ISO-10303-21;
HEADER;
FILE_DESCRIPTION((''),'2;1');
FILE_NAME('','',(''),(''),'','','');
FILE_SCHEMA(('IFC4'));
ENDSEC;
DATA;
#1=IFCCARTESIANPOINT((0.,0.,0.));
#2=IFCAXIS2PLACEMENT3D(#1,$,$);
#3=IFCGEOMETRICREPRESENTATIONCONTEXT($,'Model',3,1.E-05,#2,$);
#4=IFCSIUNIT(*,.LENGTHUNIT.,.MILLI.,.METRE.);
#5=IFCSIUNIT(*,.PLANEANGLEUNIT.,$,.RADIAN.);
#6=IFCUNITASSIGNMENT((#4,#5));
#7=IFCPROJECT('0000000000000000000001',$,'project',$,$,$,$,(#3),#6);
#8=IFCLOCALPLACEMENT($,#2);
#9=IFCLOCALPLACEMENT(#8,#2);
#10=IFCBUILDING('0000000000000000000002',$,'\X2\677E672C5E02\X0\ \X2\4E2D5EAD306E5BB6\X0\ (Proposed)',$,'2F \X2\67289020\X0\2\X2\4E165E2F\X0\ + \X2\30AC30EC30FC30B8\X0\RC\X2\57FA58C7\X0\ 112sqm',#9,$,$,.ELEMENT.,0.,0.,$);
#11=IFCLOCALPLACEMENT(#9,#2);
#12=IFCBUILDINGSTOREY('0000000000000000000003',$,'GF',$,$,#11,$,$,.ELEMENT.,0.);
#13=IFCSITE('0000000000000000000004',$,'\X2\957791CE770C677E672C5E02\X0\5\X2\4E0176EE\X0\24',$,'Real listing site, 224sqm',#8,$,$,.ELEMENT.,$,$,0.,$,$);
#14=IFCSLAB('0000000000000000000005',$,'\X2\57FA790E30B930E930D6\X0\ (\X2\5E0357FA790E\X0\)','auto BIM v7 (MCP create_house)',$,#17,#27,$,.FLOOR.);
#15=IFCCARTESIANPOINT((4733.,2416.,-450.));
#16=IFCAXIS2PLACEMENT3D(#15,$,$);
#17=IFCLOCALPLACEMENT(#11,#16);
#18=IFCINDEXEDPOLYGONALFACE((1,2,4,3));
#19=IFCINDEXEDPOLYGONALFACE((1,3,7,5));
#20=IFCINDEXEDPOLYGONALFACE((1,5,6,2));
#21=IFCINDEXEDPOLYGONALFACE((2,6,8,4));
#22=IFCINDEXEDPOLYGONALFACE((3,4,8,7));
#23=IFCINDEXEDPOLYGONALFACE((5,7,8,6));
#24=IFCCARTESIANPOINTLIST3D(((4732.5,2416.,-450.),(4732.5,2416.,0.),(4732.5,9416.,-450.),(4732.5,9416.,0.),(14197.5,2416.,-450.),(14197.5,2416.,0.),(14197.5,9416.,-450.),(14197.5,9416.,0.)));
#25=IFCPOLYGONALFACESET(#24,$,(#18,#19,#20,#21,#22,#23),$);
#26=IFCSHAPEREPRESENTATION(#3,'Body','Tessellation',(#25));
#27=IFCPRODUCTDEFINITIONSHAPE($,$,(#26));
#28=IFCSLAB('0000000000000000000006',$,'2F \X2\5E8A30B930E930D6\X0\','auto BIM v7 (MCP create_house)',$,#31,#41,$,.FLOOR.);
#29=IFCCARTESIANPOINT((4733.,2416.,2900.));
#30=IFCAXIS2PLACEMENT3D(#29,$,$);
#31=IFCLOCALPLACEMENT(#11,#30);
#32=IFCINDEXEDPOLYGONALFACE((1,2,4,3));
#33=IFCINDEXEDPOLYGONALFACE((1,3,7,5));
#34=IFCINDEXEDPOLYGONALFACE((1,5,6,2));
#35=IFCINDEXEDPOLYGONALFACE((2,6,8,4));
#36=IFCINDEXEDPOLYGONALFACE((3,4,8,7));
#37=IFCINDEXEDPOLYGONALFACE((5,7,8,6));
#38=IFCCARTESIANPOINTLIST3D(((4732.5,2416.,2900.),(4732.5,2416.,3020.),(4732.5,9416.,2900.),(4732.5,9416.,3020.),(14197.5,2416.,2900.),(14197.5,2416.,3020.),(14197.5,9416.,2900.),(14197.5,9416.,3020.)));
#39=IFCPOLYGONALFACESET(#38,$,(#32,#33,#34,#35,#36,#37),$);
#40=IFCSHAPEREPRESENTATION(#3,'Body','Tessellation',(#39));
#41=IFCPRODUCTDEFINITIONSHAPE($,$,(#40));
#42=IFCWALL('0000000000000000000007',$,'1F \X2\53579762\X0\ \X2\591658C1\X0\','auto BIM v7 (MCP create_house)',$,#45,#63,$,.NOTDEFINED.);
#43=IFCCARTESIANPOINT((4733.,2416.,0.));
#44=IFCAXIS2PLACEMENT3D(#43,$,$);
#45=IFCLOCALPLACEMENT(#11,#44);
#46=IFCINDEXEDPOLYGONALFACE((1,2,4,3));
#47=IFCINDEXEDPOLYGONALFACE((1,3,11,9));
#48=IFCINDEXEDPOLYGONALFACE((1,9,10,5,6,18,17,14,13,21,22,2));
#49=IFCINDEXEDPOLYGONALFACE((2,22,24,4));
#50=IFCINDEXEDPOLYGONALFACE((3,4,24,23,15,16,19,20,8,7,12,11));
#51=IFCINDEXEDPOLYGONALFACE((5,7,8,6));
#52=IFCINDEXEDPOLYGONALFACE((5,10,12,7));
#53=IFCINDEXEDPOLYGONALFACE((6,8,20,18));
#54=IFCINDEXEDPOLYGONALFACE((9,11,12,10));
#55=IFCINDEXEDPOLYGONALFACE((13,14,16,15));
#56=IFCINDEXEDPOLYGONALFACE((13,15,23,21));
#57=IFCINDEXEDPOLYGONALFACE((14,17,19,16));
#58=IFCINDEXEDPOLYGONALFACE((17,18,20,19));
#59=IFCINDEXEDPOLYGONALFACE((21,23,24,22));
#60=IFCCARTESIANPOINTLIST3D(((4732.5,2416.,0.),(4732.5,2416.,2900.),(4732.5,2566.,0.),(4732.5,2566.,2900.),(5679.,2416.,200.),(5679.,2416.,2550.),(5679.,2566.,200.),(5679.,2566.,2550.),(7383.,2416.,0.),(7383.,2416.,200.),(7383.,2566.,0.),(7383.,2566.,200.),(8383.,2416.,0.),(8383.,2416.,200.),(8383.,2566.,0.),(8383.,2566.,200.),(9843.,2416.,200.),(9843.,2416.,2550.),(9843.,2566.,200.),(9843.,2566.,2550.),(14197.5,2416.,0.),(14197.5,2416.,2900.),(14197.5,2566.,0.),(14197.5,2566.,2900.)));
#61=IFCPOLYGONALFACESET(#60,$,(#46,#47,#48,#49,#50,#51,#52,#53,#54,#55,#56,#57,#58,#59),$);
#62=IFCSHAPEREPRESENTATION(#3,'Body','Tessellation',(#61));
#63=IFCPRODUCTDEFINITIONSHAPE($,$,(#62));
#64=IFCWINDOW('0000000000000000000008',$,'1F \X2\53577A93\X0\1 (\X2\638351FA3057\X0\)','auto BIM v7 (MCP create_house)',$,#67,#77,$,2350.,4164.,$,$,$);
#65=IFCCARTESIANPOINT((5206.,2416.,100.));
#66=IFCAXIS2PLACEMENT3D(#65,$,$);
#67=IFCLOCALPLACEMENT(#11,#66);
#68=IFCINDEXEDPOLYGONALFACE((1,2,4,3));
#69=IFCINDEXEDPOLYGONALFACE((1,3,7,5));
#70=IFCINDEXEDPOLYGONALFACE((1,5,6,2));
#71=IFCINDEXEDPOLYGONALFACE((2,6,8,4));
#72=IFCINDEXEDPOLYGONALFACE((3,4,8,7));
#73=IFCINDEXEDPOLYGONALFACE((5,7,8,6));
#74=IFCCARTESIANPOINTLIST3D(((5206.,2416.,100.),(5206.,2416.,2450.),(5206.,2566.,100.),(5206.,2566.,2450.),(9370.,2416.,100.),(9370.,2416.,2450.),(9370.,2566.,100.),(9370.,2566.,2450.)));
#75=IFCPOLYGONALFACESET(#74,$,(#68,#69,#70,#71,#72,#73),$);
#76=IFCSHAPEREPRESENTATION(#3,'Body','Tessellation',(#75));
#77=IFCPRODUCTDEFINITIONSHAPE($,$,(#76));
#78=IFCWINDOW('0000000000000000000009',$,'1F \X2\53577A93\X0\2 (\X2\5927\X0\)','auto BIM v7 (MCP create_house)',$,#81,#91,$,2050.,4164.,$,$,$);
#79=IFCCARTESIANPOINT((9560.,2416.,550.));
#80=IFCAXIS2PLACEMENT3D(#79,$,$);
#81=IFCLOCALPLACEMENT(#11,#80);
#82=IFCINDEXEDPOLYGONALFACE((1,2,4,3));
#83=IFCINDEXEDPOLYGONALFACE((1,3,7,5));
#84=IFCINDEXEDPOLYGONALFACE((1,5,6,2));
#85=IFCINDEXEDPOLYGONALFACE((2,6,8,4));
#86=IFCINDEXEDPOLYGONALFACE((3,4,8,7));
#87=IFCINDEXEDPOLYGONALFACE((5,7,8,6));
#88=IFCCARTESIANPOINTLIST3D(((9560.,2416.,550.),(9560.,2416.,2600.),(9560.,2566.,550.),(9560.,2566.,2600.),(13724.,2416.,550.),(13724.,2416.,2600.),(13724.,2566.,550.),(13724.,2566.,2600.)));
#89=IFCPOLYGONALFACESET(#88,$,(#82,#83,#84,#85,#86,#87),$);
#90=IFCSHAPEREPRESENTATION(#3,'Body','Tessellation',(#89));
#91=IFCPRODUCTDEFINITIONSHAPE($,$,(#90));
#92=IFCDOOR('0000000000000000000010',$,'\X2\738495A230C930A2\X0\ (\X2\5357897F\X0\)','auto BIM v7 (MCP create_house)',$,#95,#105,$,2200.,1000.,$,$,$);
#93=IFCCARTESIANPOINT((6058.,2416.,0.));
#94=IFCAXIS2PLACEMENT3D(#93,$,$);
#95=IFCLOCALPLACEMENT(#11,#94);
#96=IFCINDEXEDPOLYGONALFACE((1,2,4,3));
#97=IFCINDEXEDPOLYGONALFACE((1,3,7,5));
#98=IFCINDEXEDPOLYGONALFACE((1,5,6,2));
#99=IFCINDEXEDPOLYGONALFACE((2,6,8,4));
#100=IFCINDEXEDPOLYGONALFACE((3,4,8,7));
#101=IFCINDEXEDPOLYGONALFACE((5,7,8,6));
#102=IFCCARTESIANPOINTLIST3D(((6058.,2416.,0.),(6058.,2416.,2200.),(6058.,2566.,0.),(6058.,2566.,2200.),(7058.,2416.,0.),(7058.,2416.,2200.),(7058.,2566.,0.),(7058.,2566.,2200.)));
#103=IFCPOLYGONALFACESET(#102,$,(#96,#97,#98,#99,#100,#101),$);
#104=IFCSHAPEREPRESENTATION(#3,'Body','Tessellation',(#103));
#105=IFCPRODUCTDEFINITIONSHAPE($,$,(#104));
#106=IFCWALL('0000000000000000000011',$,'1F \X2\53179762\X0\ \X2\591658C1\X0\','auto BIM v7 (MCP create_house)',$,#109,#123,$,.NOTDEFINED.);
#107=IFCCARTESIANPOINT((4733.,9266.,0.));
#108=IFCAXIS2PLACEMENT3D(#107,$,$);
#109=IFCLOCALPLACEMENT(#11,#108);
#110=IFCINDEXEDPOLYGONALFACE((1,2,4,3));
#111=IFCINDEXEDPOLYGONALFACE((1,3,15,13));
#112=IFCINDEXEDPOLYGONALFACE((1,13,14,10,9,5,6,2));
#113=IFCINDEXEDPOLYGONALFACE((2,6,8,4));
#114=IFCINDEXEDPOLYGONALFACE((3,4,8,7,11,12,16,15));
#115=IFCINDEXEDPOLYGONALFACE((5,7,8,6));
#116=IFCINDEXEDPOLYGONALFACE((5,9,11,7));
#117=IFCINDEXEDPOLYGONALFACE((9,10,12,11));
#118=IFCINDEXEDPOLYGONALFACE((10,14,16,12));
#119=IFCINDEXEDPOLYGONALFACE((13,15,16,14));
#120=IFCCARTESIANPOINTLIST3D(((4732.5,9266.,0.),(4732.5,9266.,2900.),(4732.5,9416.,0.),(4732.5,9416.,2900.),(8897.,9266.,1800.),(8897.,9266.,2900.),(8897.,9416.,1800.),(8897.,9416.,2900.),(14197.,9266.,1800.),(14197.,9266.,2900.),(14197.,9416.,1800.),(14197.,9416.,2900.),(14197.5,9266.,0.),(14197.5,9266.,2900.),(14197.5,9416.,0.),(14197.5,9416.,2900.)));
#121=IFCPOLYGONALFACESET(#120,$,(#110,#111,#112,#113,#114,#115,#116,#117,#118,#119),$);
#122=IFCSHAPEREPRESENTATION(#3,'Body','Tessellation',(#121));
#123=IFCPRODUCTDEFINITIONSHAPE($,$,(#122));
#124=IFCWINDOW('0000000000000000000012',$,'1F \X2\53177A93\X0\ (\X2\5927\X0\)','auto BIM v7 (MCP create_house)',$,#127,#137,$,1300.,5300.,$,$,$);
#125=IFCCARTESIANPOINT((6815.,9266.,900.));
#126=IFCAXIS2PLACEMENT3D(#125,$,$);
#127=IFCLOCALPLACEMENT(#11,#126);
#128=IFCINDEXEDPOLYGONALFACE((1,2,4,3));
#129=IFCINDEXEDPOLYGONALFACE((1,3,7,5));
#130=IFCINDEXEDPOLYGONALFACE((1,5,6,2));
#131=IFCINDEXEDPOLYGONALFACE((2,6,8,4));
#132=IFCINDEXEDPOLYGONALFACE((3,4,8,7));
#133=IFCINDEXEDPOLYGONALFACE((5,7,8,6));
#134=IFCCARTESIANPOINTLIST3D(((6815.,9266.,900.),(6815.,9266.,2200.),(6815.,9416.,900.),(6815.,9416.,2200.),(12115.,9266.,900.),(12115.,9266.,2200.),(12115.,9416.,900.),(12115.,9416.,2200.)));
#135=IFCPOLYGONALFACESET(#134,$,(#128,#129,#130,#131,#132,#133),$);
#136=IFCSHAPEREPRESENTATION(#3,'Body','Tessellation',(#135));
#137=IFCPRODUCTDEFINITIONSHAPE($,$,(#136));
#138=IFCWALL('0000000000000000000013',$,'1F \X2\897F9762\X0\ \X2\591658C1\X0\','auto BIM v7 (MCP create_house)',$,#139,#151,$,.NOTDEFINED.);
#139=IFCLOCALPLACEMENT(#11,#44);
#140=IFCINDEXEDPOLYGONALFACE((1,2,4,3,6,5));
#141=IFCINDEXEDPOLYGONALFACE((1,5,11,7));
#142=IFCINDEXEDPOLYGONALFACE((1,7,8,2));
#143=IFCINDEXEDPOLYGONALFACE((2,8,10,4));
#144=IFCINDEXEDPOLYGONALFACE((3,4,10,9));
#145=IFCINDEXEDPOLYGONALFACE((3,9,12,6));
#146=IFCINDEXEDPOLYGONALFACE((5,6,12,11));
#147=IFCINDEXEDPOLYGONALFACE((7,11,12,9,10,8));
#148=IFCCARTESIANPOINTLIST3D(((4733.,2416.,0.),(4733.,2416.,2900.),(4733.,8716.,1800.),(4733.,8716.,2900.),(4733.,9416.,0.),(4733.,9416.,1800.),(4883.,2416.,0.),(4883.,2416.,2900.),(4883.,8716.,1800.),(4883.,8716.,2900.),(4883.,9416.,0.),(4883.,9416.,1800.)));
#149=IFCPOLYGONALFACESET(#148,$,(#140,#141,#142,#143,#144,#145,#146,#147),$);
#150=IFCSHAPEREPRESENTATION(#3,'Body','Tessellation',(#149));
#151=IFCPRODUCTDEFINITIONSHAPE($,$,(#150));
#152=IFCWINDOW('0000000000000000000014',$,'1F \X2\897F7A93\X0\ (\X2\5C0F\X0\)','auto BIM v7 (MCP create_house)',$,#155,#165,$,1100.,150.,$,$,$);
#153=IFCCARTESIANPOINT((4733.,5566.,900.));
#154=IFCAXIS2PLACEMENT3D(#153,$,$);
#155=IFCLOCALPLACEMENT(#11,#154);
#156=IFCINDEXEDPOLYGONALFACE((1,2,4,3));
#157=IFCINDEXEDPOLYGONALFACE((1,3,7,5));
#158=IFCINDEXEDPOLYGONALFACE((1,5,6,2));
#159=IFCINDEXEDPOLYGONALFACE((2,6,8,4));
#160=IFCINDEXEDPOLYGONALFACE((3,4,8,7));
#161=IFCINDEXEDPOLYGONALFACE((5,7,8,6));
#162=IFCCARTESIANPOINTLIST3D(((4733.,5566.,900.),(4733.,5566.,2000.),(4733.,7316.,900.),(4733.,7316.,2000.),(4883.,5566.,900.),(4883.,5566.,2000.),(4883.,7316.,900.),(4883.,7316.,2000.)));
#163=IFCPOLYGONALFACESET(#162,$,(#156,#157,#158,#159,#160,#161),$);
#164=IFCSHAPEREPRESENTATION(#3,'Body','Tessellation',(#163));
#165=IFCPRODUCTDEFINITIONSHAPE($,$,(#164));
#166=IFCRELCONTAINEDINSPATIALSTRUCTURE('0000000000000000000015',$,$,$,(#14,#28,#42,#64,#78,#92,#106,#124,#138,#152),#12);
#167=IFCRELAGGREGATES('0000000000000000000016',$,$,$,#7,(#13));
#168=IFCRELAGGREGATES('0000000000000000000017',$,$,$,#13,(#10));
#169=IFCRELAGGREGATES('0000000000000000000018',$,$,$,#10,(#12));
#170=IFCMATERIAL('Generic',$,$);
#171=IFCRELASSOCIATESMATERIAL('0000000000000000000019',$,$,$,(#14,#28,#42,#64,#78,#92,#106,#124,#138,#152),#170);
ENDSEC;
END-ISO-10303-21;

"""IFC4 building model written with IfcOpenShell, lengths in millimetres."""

from ifc_helpers import new_model, si_unit, frame, frame_2d, origin, place, context, project, spatial, rectangle, extrude, material, element, fill, save


model = new_model("IFC4")

# Units and contexts
model_context = context("Model", 3, precision=1e-05, world=origin())
ifc_project = project(units=[si_unit("LENGTHUNIT", "METRE", prefix="MILLI"), si_unit("PLANEANGLEUNIT", "RADIAN")], contexts=[model_context])

# Site, building, storey
site_placement = place(None, origin())
site = spatial("IfcSite", under=ifc_project, at=site_placement, Name="長野県松本市5丁目24", ObjectType="Real listing site, 224sqm", CompositionType="ELEMENT", RefElevation=0.0)
building_placement = place(site_placement, origin())
building = spatial("IfcBuilding", under=site, at=building_placement, Name="松本市 中庭の家 (Proposed)", ObjectType="2F 木造2世帯 + ガレージRC基壇 112sqm", CompositionType="ELEMENT", ElevationOfRefHeight=0.0, ElevationOfTerrain=0.0)
storey_placement = place(building_placement, origin())
storey = spatial("IfcBuildingStorey", under=building, at=storey_placement, Name="GF", CompositionType="ELEMENT", Elevation=0.0)

# Slabs
ifc_material = material(Name="Generic")
slab_1_placement = place(storey_placement, frame((4733.0, 2416.0, -450.0)))
element("IfcSlab", 1, at=slab_1_placement, inside=storey, material=ifc_material, Name="基礎スラブ (布基礎)", Description="auto BIM v7 (MCP create_house)", PredefinedType="FLOOR", context=model_context, shape_type="SweptSolid", body=[
    extrude(rectangle(XDim=9465.0, YDim=7000.0, at=frame_2d((4732.0, 3500.0))), frame((4733.0, 2416.0, -450.0)), (0.0, 0.0, 1.0), 450.0),
])
slab_2_placement = place(storey_placement, frame((4733.0, 2416.0, 2900.0)))
element("IfcSlab", 2, at=slab_2_placement, inside=storey, material=ifc_material, Name="2F 床スラブ", Description="auto BIM v7 (MCP create_house)", PredefinedType="FLOOR", context=model_context, shape_type="SweptSolid", body=[
    extrude(rectangle(XDim=9465.0, YDim=7000.0, at=frame_2d((4732.0, 3500.0))), frame((4733.0, 2416.0, 2900.0)), (0.0, 0.0, 1.0), 120.0),
])

# Wall, openings, windows, door
wall_1_placement = place(storey_placement, frame((4733.0, 2416.0, 0.0)))
wall_1 = element("IfcWall", 3, at=wall_1_placement, inside=storey, material=ifc_material, Name="1F 南面 外壁", Description="auto BIM v7 (MCP create_house)", PredefinedType="NOTDEFINED", context=model_context, shape_type="SweptSolid", body=[
    extrude(rectangle(XDim=9465.0, YDim=150.0, at=frame_2d((4732.0, 75.0))), frame((4733.0, 2416.0, 0.0)), (0.0, 0.0, 1.0), 2900.0),
])
opening_1_placement = place(storey_placement, frame((5206.0, 2416.0, 100.0)))
opening_1 = element("IfcOpeningElement", 4, at=opening_1_placement, cuts=wall_1, PredefinedType="NOTDEFINED", context=model_context, shape_type="SweptSolid", body=[
    extrude(rectangle(XDim=4164.0, YDim=150.0, at=frame_2d((2082.0, 75.0))), frame((5206.0, 2416.0, 100.0)), (0.0, 0.0, 1.0), 2350.0),
])
opening_2_placement = place(storey_placement, frame((9560.0, 2416.0, 550.0)))
opening_2 = element("IfcOpeningElement", 5, at=opening_2_placement, cuts=wall_1, PredefinedType="NOTDEFINED", context=model_context, shape_type="SweptSolid", body=[
    extrude(rectangle(XDim=4164.0, YDim=150.0, at=frame_2d((2082.0, 75.0))), frame((9560.0, 2416.0, 550.0)), (0.0, 0.0, 1.0), 2050.0),
])
opening_3_placement = place(storey_placement, frame((6058.0, 2416.0, 0.0)))
opening_3 = element("IfcOpeningElement", 6, at=opening_3_placement, cuts=wall_1, PredefinedType="NOTDEFINED", context=model_context, shape_type="SweptSolid", body=[
    extrude(rectangle(XDim=1000.0, YDim=150.0, at=frame_2d((500.0, 75.0))), frame((6058.0, 2416.0, 0.0)), (0.0, 0.0, 1.0), 2200.0),
])
window_1_placement = place(storey_placement, frame((5206.0, 2416.0, 100.0)))
window_1 = element("IfcWindow", 7, at=window_1_placement, inside=storey, material=ifc_material, Name="1F 南窓1 (掃出し)", Description="auto BIM v7 (MCP create_house)", OverallHeight=2350.0, OverallWidth=4164.0, context=model_context, shape_type="SweptSolid", body=[
    extrude(rectangle(XDim=4164.0, YDim=150.0, at=frame_2d((2082.0, 75.0))), frame((5206.0, 2416.0, 100.0)), (0.0, 0.0, 1.0), 2350.0),
])
fill(opening_1, window_1)
window_2_placement = place(storey_placement, frame((9560.0, 2416.0, 550.0)))
window_2 = element("IfcWindow", 8, at=window_2_placement, inside=storey, material=ifc_material, Name="1F 南窓2 (大)", Description="auto BIM v7 (MCP create_house)", OverallHeight=2050.0, OverallWidth=4164.0, context=model_context, shape_type="SweptSolid", body=[
    extrude(rectangle(XDim=4164.0, YDim=150.0, at=frame_2d((2082.0, 75.0))), frame((9560.0, 2416.0, 550.0)), (0.0, 0.0, 1.0), 2050.0),
])
fill(opening_2, window_2)
door_placement = place(storey_placement, frame((6058.0, 2416.0, 0.0)))
door = element("IfcDoor", 9, at=door_placement, inside=storey, material=ifc_material, Name="玄関ドア (南西)", Description="auto BIM v7 (MCP create_house)", OverallHeight=2200.0, OverallWidth=1000.0, context=model_context, shape_type="SweptSolid", body=[
    extrude(rectangle(XDim=1000.0, YDim=150.0, at=frame_2d((500.0, 75.0))), frame((6058.0, 2416.0, 0.0)), (0.0, 0.0, 1.0), 2200.0),
])
fill(opening_3, door)

# Walls, openings, windows
wall_2_placement = place(storey_placement, frame((4733.0, 9266.0, 0.0)))
wall_2 = element("IfcWall", 10, at=wall_2_placement, inside=storey, material=ifc_material, Name="1F 北面 外壁", Description="auto BIM v7 (MCP create_house)", PredefinedType="NOTDEFINED", context=model_context, shape_type="SweptSolid", body=[
    extrude(rectangle(XDim=9465.0, YDim=150.0, at=frame_2d((4732.0, 75.0))), frame((4733.0, 9266.0, 0.0)), (0.0, 0.0, 1.0), 2900.0),
])
opening_4_placement = place(storey_placement, frame((6815.0, 9266.0, 900.0)))
opening_4 = element("IfcOpeningElement", 11, at=opening_4_placement, cuts=wall_2, PredefinedType="NOTDEFINED", context=model_context, shape_type="SweptSolid", body=[
    extrude(rectangle(XDim=5300.0, YDim=150.0, at=frame_2d((2650.0, 75.0))), frame((6815.0, 9266.0, 900.0)), (0.0, 0.0, 1.0), 1300.0),
])
window_3_placement = place(storey_placement, frame((6815.0, 9266.0, 900.0)))
window_3 = element("IfcWindow", 12, at=window_3_placement, inside=storey, material=ifc_material, Name="1F 北窓 (大)", Description="auto BIM v7 (MCP create_house)", OverallHeight=1300.0, OverallWidth=5300.0, context=model_context, shape_type="SweptSolid", body=[
    extrude(rectangle(XDim=5300.0, YDim=150.0, at=frame_2d((2650.0, 75.0))), frame((6815.0, 9266.0, 900.0)), (0.0, 0.0, 1.0), 1300.0),
])
fill(opening_4, window_3)
wall_3_placement = place(storey_placement, frame((4733.0, 2416.0, 0.0)))
wall_3 = element("IfcWall", 13, at=wall_3_placement, inside=storey, material=ifc_material, Name="1F 西面 外壁", Description="auto BIM v7 (MCP create_house)", PredefinedType="NOTDEFINED", context=model_context, shape_type="SweptSolid", body=[
    extrude(rectangle(XDim=150.0, YDim=7000.0, at=frame_2d((75.0, 3500.0))), frame((4733.0, 2416.0, 0.0)), (0.0, 0.0, 1.0), 2900.0),
])
opening_5_placement = place(storey_placement, frame((4733.0, 5566.0, 900.0)))
opening_5 = element("IfcOpeningElement", 14, at=opening_5_placement, cuts=wall_3, PredefinedType="NOTDEFINED", context=model_context, shape_type="SweptSolid", body=[
    extrude(rectangle(XDim=150.0, YDim=1750.0, at=frame_2d((75.0, 875.0))), frame((4733.0, 5566.0, 900.0)), (0.0, 0.0, 1.0), 1100.0),
])
window_4_placement = place(storey_placement, frame((4733.0, 5566.0, 900.0)))
window_4 = element("IfcWindow", 15, at=window_4_placement, inside=storey, material=ifc_material, Name="1F 西窓 (小)", Description="auto BIM v7 (MCP create_house)", OverallHeight=1100.0, OverallWidth=150.0, context=model_context, shape_type="SweptSolid", body=[
    extrude(rectangle(XDim=150.0, YDim=1750.0, at=frame_2d((75.0, 875.0))), frame((4733.0, 5566.0, 900.0)), (0.0, 0.0, 1.0), 1100.0),
])
fill(opening_5, window_4)

save(model, "model.ifc")
